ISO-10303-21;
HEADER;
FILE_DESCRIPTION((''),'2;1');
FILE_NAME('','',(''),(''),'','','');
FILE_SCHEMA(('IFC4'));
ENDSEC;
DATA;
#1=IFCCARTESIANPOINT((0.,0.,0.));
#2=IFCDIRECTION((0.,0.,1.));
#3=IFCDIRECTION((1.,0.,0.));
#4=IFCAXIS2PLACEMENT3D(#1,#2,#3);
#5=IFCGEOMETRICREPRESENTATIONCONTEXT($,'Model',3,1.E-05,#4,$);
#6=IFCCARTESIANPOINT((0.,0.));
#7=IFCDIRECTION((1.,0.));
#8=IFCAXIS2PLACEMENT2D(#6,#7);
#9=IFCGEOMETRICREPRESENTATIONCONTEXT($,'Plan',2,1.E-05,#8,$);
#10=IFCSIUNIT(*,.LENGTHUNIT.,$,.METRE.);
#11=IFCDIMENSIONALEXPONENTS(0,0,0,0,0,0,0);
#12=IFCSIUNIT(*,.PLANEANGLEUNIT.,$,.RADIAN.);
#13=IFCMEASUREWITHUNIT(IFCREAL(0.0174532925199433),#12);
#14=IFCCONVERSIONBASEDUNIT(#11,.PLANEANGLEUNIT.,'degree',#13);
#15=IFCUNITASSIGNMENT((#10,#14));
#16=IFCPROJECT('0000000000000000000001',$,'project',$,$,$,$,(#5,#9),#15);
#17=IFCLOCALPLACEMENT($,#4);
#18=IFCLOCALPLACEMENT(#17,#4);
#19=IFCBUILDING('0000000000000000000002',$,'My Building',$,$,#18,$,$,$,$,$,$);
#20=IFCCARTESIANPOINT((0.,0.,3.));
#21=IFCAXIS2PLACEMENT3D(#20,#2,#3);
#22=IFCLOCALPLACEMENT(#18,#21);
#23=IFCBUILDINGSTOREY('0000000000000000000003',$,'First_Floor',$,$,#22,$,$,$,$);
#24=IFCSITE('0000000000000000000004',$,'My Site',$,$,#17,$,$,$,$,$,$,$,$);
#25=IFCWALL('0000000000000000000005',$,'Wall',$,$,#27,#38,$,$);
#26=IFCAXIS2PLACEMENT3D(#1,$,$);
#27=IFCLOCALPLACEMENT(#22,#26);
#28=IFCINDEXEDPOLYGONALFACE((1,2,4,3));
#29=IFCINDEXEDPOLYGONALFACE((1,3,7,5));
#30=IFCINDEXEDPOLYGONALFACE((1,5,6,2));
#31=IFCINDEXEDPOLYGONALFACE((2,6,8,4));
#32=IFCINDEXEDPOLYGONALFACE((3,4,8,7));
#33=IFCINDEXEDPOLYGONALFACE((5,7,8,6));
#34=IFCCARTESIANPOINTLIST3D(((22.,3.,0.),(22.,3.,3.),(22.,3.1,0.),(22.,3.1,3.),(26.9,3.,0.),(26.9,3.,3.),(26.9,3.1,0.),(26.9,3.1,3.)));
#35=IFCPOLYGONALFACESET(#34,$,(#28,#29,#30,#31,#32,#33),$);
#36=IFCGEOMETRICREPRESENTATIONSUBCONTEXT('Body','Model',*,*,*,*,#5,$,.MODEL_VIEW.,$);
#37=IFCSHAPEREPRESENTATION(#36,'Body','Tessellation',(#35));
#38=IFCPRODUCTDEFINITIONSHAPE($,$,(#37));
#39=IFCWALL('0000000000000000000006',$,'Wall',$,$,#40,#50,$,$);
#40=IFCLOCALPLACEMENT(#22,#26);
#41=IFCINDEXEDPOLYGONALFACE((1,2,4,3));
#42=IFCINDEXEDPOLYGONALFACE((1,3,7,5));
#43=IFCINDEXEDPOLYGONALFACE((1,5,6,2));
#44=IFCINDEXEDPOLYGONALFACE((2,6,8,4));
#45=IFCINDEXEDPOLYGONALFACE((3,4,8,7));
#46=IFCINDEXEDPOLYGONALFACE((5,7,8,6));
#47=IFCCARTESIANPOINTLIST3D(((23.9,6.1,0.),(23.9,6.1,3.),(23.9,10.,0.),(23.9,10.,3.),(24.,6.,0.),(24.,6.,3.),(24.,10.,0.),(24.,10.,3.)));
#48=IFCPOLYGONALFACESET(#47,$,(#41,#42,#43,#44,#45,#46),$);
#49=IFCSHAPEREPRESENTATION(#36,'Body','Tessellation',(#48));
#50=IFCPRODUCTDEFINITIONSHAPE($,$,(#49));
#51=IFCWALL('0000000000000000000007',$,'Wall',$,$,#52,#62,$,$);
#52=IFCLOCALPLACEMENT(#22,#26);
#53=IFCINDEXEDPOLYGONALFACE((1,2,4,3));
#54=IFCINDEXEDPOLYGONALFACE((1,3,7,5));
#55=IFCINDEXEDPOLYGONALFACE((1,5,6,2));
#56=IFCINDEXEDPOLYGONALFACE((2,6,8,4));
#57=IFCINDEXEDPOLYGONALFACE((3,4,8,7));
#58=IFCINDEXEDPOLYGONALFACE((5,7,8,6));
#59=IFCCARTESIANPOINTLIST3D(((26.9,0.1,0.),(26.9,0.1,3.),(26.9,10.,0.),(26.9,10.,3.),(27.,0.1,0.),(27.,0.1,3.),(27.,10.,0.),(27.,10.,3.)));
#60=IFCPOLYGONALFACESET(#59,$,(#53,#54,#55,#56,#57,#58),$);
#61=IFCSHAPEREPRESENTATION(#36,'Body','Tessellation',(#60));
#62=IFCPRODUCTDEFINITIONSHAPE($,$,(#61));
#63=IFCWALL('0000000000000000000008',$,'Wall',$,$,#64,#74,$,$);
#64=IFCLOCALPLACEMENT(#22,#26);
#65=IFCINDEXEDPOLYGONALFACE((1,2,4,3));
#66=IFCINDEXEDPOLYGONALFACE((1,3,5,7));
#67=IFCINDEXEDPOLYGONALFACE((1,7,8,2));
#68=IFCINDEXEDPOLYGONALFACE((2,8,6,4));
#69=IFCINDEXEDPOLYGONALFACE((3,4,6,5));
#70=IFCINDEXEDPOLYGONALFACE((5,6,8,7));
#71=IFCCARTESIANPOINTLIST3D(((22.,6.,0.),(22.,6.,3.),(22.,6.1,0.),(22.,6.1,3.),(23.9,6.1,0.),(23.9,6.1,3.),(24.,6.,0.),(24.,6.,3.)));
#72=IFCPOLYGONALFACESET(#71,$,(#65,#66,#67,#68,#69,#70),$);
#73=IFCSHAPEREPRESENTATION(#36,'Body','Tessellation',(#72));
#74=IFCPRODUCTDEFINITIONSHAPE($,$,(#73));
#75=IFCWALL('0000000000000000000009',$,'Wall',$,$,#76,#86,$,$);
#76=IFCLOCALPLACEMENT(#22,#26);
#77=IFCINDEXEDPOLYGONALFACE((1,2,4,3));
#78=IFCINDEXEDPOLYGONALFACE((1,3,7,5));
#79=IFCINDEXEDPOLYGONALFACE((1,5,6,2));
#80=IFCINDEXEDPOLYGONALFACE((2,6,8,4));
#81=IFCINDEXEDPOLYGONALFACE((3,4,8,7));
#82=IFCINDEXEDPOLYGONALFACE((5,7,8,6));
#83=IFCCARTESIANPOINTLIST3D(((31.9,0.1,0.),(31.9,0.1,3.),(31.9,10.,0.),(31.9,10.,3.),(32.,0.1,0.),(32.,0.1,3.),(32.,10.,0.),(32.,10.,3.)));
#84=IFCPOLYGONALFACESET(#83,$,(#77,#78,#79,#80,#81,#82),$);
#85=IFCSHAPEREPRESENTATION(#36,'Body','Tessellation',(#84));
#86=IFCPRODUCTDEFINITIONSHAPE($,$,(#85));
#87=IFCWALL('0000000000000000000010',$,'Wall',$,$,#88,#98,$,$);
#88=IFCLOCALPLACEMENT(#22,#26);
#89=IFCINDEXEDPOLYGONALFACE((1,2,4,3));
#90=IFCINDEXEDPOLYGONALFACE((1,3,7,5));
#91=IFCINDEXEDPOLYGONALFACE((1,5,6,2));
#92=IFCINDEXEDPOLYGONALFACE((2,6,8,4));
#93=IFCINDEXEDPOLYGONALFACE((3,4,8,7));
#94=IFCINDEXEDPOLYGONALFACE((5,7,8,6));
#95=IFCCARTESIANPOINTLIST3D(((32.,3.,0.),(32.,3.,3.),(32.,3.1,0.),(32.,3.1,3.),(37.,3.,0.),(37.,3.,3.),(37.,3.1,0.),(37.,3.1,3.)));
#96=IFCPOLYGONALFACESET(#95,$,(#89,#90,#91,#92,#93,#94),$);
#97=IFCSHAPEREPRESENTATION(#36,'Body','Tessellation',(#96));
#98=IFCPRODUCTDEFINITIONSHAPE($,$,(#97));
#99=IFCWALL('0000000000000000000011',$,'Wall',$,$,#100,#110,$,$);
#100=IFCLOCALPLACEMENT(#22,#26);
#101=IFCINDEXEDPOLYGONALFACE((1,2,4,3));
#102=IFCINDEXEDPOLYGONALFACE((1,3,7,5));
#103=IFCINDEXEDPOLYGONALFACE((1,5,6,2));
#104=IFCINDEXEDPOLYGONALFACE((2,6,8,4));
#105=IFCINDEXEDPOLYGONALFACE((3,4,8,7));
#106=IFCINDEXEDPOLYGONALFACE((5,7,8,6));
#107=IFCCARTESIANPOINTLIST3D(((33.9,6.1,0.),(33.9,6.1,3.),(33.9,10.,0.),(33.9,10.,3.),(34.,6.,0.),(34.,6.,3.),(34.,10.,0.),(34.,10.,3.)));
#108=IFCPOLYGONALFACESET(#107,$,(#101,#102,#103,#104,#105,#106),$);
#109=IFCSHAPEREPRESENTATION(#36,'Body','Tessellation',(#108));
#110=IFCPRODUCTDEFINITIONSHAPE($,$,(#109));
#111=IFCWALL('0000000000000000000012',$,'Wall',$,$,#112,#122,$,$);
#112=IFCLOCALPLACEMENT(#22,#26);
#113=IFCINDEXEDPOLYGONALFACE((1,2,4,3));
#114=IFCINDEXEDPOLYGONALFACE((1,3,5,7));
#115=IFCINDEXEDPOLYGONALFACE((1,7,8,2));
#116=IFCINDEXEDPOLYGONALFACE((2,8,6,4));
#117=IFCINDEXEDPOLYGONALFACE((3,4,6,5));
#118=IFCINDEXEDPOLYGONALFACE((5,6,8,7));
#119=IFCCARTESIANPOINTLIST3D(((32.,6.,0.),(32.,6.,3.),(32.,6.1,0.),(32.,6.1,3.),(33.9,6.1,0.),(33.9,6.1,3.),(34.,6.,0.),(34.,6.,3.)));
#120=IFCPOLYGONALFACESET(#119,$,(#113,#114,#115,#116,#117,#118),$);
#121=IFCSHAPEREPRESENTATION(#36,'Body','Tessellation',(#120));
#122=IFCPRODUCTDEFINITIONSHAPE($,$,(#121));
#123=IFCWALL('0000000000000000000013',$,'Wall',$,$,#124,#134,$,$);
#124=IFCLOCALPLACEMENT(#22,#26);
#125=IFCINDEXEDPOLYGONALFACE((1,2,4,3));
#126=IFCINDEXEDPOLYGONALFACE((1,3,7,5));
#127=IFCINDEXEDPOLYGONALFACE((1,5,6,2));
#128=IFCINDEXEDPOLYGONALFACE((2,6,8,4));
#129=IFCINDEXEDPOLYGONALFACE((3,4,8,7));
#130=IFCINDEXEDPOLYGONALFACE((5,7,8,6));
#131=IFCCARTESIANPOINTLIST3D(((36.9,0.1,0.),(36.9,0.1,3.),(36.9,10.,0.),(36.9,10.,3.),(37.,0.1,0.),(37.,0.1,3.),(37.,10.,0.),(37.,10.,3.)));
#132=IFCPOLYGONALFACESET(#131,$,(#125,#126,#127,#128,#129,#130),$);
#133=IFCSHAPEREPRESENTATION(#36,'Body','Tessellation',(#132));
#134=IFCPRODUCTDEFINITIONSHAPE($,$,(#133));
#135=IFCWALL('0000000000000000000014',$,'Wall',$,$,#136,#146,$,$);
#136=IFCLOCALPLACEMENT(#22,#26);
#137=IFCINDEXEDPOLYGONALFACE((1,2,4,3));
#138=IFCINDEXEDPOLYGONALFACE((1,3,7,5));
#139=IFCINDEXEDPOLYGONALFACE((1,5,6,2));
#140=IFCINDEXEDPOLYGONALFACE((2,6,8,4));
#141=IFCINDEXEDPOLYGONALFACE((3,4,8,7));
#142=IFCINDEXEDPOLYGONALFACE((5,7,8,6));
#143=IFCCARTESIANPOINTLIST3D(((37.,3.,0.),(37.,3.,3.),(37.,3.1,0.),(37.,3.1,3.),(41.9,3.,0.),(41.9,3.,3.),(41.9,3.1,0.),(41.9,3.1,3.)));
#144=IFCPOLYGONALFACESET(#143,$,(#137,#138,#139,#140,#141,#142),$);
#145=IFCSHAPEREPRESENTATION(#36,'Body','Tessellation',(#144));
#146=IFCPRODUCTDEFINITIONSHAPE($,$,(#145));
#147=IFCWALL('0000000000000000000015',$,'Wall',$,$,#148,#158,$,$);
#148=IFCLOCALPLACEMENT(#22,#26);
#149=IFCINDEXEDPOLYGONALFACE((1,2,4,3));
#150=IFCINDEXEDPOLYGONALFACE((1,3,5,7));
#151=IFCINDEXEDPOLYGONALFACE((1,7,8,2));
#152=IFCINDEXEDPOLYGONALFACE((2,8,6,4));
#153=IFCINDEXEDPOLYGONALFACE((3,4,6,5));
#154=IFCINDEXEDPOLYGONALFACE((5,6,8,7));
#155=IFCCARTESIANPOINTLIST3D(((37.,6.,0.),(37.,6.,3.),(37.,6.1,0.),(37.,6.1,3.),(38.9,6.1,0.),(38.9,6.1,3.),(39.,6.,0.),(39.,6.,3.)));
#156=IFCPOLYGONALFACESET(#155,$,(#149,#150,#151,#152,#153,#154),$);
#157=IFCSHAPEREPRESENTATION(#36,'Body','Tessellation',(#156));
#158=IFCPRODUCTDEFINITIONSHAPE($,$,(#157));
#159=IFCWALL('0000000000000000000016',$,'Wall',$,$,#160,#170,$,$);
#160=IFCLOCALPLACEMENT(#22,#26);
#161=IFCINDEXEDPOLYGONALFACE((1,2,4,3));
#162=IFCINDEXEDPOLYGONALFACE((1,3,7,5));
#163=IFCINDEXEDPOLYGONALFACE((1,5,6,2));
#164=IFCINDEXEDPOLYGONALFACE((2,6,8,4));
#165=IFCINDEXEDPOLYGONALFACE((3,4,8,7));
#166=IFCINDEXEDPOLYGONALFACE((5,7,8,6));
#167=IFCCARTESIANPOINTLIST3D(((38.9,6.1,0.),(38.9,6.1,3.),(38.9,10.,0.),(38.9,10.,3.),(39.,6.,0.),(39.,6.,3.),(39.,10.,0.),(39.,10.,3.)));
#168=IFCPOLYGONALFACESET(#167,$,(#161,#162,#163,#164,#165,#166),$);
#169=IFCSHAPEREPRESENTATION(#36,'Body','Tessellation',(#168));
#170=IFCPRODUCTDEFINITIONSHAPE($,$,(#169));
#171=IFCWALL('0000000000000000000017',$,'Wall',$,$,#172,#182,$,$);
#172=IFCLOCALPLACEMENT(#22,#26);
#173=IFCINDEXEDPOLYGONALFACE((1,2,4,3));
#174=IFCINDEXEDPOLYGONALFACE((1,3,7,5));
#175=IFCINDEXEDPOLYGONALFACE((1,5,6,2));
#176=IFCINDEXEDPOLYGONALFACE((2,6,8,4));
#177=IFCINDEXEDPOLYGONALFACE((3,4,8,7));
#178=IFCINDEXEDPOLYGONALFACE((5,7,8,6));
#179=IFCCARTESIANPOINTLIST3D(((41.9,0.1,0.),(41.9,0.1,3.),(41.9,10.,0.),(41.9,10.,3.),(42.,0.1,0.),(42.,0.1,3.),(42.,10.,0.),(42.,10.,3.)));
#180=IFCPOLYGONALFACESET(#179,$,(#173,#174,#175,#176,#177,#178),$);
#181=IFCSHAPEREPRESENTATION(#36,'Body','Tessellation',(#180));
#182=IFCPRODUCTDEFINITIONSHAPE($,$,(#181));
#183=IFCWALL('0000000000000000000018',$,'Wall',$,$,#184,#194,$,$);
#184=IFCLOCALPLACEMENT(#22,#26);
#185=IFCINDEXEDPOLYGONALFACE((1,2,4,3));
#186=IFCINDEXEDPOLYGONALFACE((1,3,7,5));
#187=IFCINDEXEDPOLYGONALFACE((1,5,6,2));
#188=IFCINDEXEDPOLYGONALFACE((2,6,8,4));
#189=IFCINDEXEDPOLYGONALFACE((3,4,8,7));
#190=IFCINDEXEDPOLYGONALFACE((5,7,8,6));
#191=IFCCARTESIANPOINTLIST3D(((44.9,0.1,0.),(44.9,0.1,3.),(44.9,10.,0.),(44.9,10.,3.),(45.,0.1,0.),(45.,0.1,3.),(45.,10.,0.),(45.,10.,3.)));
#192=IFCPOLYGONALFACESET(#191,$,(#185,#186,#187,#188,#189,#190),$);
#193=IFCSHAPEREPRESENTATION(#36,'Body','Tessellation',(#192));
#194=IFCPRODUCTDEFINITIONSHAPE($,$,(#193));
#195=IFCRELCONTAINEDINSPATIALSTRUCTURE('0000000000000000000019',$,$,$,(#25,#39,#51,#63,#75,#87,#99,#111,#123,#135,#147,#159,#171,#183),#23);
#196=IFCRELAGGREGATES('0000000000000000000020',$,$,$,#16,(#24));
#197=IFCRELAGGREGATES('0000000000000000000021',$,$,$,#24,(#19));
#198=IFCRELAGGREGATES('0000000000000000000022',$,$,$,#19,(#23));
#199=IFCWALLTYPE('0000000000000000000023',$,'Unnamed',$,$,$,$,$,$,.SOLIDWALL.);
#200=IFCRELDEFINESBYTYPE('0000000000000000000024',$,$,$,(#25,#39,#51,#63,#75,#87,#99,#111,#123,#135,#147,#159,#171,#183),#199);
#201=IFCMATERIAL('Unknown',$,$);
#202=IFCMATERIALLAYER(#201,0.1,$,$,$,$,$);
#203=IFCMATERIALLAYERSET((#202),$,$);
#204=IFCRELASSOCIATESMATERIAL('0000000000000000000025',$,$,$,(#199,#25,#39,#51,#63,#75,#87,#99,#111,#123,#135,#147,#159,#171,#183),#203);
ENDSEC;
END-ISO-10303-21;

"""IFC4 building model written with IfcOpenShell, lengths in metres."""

from ifc_helpers import new_model, entity, si_unit, converted_unit, frame, origin_with_axes, origin_2d_with_axis, place, context, subcontext, project, spatial, line, indexed_curve, outline, extrude, material, layer, layer_set, layer_usage, type_object, element, save


model = new_model("IFC4")

# Units and contexts
model_context = context("Model", 3, precision=1e-05, world=origin_with_axes())
plan_context = context("Plan", 2, precision=1e-05, world=origin_2d_with_axis())
body_context = subcontext(model_context, "Body", "Model", "MODEL_VIEW")
ifc_project = project(units=[si_unit("LENGTHUNIT", "METRE"), converted_unit("PLANEANGLEUNIT", "degree", entity("IfcReal", 0.0174532925199433), si_unit("PLANEANGLEUNIT", "RADIAN"), dimensions=[0, 0, 0, 0, 0, 0, 0])], contexts=[model_context, plan_context])

# Site, building, storey
site_placement = place(None, origin_with_axes())
site = spatial("IfcSite", under=ifc_project, at=site_placement, Name="My Site")
building_placement = place(site_placement, origin_with_axes())
building = spatial("IfcBuilding", under=site, at=building_placement, Name="My Building")
storey_placement = place(building_placement, frame((0.0, 0.0, 3.0), z_axis=(0.0, 0.0, 1.0), x_axis=(1.0, 0.0, 0.0)))
storey = spatial("IfcBuildingStorey", under=building, at=storey_placement, Name="First_Floor")

# Walls
ifc_material = material(Name="Unknown")
ifc_layer = layer(ifc_material, 0.1)
ifc_layer_set = layer_set([ifc_layer])
ifc_layer_usage_1 = layer_usage(ifc_layer_set, "AXIS2", "POSITIVE", 0.0)
wall_type = type_object("IfcWallType", Name="Unnamed", PredefinedType="SOLIDWALL", material=ifc_layer_set)
wall_1_placement = place(storey_placement, frame((22.0, 3.0, 0.0), z_axis=(0.0, 0.0, 1.0), x_axis=(1.0, 0.0, 0.0)))
element("IfcWall", 1, at=wall_1_placement, inside=storey, type_object=wall_type, material=ifc_layer_usage_1, Name="Wall", context=body_context, shape_type="SweptSolid", body=[
    extrude(outline(indexed_curve([(0.0, 0.0), (0.0, 0.1), (4.9, 0.1), (4.9, 0.0)], segments=[line(1, 2, 3, 4, 1)])), origin_with_axes(), (0.0, 0.0, 1.0), 3.0),
])
ifc_layer_usage_2 = layer_usage(ifc_layer_set, "AXIS2", "POSITIVE", 0.0)
wall_2_placement = place(storey_placement, frame((24.0, 6.0, 0.0), z_axis=(0.0, 0.0, 1.0), x_axis=(0.0, 1.0, 0.0)))
element("IfcWall", 2, at=wall_2_placement, inside=storey, type_object=wall_type, material=ifc_layer_usage_2, Name="Wall", context=body_context, shape_type="SweptSolid", body=[
    extrude(outline(indexed_curve([(0.0, 0.0), (0.1, 0.1), (4.0, 0.1), (4.0, 0.0)], segments=[line(1, 2, 3, 4, 1)])), origin_with_axes(), (0.0, 0.0, 1.0), 3.0),
])
ifc_layer_usage_3 = layer_usage(ifc_layer_set, "AXIS2", "POSITIVE", 0.0)
wall_3_placement = place(storey_placement, frame((26.9, 10.0, 0.0), z_axis=(0.0, 0.0, 1.0), x_axis=(0.0, -1.0, 0.0)))
element("IfcWall", 3, at=wall_3_placement, inside=storey, type_object=wall_type, material=ifc_layer_usage_3, Name="Wall", context=body_context, shape_type="SweptSolid", body=[
    extrude(outline(indexed_curve([(0.0, 0.0), (0.0, 0.1), (9.9, 0.1), (9.9, 0.0)], segments=[line(1, 2, 3, 4, 1)])), origin_with_axes(), (0.0, 0.0, 1.0), 3.0),
])
ifc_layer_usage_4 = layer_usage(ifc_layer_set, "AXIS2", "POSITIVE", 0.0)
wall_4_placement = place(storey_placement, frame((22.0, 6.0, 0.0), z_axis=(0.0, 0.0, 1.0), x_axis=(1.0, 0.0, 0.0)))
element("IfcWall", 4, at=wall_4_placement, inside=storey, type_object=wall_type, material=ifc_layer_usage_4, Name="Wall", context=body_context, shape_type="SweptSolid", body=[
    extrude(outline(indexed_curve([(0.0, 0.0), (0.0, 0.1), (1.9, 0.1), (2.0, 0.0)], segments=[line(1, 2, 3, 4, 1)])), origin_with_axes(), (0.0, 0.0, 1.0), 3.0),
])
ifc_layer_usage_5 = layer_usage(ifc_layer_set, "AXIS2", "POSITIVE", 0.0)
wall_5_placement = place(storey_placement, frame((31.9, 10.0, 0.0), z_axis=(0.0, 0.0, 1.0), x_axis=(0.0, -1.0, 0.0)))
element("IfcWall", 5, at=wall_5_placement, inside=storey, type_object=wall_type, material=ifc_layer_usage_5, Name="Wall", context=body_context, shape_type="SweptSolid", body=[
    extrude(outline(indexed_curve([(0.0, 0.0), (0.0, 0.1), (9.9, 0.1), (9.9, 0.0)], segments=[line(1, 2, 3, 4, 1)])), origin_with_axes(), (0.0, 0.0, 1.0), 3.0),
])
ifc_layer_usage_6 = layer_usage(ifc_layer_set, "AXIS2", "POSITIVE", 0.0)
wall_6_placement = place(storey_placement, frame((32.0, 3.0, 0.0), z_axis=(0.0, 0.0, 1.0), x_axis=(1.0, 0.0, 0.0)))
element("IfcWall", 6, at=wall_6_placement, inside=storey, type_object=wall_type, material=ifc_layer_usage_6, Name="Wall", context=body_context, shape_type="SweptSolid", body=[
    extrude(outline(indexed_curve([(0.0, 0.0), (0.0, 0.1), (5.0, 0.1), (5.0, 0.0)], segments=[line(1, 2, 3, 4, 1)])), origin_with_axes(), (0.0, 0.0, 1.0), 3.0),
])
ifc_layer_usage_7 = layer_usage(ifc_layer_set, "AXIS2", "POSITIVE", 0.0)
wall_7_placement = place(storey_placement, frame((34.0, 6.0, 0.0), z_axis=(0.0, 0.0, 1.0), x_axis=(0.0, 1.0, 0.0)))
element("IfcWall", 7, at=wall_7_placement, inside=storey, type_object=wall_type, material=ifc_layer_usage_7, Name="Wall", context=body_context, shape_type="SweptSolid", body=[
    extrude(outline(indexed_curve([(0.0, 0.0), (0.1, 0.1), (4.0, 0.1), (4.0, 0.0)], segments=[line(1, 2, 3, 4, 1)])), origin_with_axes(), (0.0, 0.0, 1.0), 3.0),
])
ifc_layer_usage_8 = layer_usage(ifc_layer_set, "AXIS2", "POSITIVE", 0.0)
wall_8_placement = place(storey_placement, frame((32.0, 6.0, 0.0), z_axis=(0.0, 0.0, 1.0), x_axis=(1.0, 0.0, 0.0)))
element("IfcWall", 8, at=wall_8_placement, inside=storey, type_object=wall_type, material=ifc_layer_usage_8, Name="Wall", context=body_context, shape_type="SweptSolid", body=[
    extrude(outline(indexed_curve([(0.0, 0.0), (0.0, 0.1), (1.9, 0.1), (2.0, 0.0)], segments=[line(1, 2, 3, 4, 1)])), origin_with_axes(), (0.0, 0.0, 1.0), 3.0),
])
ifc_layer_usage_9 = layer_usage(ifc_layer_set, "AXIS2", "POSITIVE", 0.0)
wall_9_placement = place(storey_placement, frame((36.9, 10.0, 0.0), z_axis=(0.0, 0.0, 1.0), x_axis=(0.0, -1.0, 0.0)))
element("IfcWall", 9, at=wall_9_placement, inside=storey, type_object=wall_type, material=ifc_layer_usage_9, Name="Wall", context=body_context, shape_type="SweptSolid", body=[
    extrude(outline(indexed_curve([(0.0, 0.0), (0.0, 0.1), (9.9, 0.1), (9.9, 0.0)], segments=[line(1, 2, 3, 4, 1)])), origin_with_axes(), (0.0, 0.0, 1.0), 3.0),
])
ifc_layer_usage_10 = layer_usage(ifc_layer_set, "AXIS2", "POSITIVE", 0.0)
wall_10_placement = place(storey_placement, frame((37.0, 3.0, 0.0), z_axis=(0.0, 0.0, 1.0), x_axis=(1.0, 0.0, 0.0)))
element("IfcWall", 10, at=wall_10_placement, inside=storey, type_object=wall_type, material=ifc_layer_usage_10, Name="Wall", context=body_context, shape_type="SweptSolid", body=[
    extrude(outline(indexed_curve([(0.0, 0.0), (0.0, 0.1), (4.9, 0.1), (4.9, 0.0)], segments=[line(1, 2, 3, 4, 1)])), origin_with_axes(), (0.0, 0.0, 1.0), 3.0),
])
ifc_layer_usage_11 = layer_usage(ifc_layer_set, "AXIS2", "POSITIVE", 0.0)
wall_11_placement = place(storey_placement, frame((37.0, 6.0, 0.0), z_axis=(0.0, 0.0, 1.0), x_axis=(1.0, 0.0, 0.0)))
element("IfcWall", 11, at=wall_11_placement, inside=storey, type_object=wall_type, material=ifc_layer_usage_11, Name="Wall", context=body_context, shape_type="SweptSolid", body=[
    extrude(outline(indexed_curve([(0.0, 0.0), (0.0, 0.1), (1.9, 0.1), (2.0, 0.0)], segments=[line(1, 2, 3, 4, 1)])), origin_with_axes(), (0.0, 0.0, 1.0), 3.0),
])
ifc_layer_usage_12 = layer_usage(ifc_layer_set, "AXIS2", "POSITIVE", 0.0)
wall_12_placement = place(storey_placement, frame((39.0, 6.0, 0.0), z_axis=(0.0, 0.0, 1.0), x_axis=(0.0, 1.0, 0.0)))
element("IfcWall", 12, at=wall_12_placement, inside=storey, type_object=wall_type, material=ifc_layer_usage_12, Name="Wall", context=body_context, shape_type="SweptSolid", body=[
    extrude(outline(indexed_curve([(0.0, 0.0), (0.1, 0.1), (4.0, 0.1), (4.0, 0.0)], segments=[line(1, 2, 3, 4, 1)])), origin_with_axes(), (0.0, 0.0, 1.0), 3.0),
])
ifc_layer_usage_13 = layer_usage(ifc_layer_set, "AXIS2", "POSITIVE", 0.0)
wall_13_placement = place(storey_placement, frame((41.9, 10.0, 0.0), z_axis=(0.0, 0.0, 1.0), x_axis=(0.0, -1.0, 0.0)))
element("IfcWall", 13, at=wall_13_placement, inside=storey, type_object=wall_type, material=ifc_layer_usage_13, Name="Wall", context=body_context, shape_type="SweptSolid", body=[
    extrude(outline(indexed_curve([(0.0, 0.0), (0.0, 0.1), (9.9, 0.1), (9.9, 0.0)], segments=[line(1, 2, 3, 4, 1)])), origin_with_axes(), (0.0, 0.0, 1.0), 3.0),
])
ifc_layer_usage_14 = layer_usage(ifc_layer_set, "AXIS2", "POSITIVE", 0.0)
wall_14_placement = place(storey_placement, frame((44.9, 10.0, 0.0), z_axis=(0.0, 0.0, 1.0), x_axis=(0.0, -1.0, 0.0)))
element("IfcWall", 14, at=wall_14_placement, inside=storey, type_object=wall_type, material=ifc_layer_usage_14, Name="Wall", context=body_context, shape_type="SweptSolid", body=[
    extrude(outline(indexed_curve([(0.0, 0.0), (0.0, 0.1), (9.9, 0.1), (9.9, 0.0)], segments=[line(1, 2, 3, 4, 1)])), origin_with_axes(), (0.0, 0.0, 1.0), 3.0),
])

save(model, "model.ifc")
